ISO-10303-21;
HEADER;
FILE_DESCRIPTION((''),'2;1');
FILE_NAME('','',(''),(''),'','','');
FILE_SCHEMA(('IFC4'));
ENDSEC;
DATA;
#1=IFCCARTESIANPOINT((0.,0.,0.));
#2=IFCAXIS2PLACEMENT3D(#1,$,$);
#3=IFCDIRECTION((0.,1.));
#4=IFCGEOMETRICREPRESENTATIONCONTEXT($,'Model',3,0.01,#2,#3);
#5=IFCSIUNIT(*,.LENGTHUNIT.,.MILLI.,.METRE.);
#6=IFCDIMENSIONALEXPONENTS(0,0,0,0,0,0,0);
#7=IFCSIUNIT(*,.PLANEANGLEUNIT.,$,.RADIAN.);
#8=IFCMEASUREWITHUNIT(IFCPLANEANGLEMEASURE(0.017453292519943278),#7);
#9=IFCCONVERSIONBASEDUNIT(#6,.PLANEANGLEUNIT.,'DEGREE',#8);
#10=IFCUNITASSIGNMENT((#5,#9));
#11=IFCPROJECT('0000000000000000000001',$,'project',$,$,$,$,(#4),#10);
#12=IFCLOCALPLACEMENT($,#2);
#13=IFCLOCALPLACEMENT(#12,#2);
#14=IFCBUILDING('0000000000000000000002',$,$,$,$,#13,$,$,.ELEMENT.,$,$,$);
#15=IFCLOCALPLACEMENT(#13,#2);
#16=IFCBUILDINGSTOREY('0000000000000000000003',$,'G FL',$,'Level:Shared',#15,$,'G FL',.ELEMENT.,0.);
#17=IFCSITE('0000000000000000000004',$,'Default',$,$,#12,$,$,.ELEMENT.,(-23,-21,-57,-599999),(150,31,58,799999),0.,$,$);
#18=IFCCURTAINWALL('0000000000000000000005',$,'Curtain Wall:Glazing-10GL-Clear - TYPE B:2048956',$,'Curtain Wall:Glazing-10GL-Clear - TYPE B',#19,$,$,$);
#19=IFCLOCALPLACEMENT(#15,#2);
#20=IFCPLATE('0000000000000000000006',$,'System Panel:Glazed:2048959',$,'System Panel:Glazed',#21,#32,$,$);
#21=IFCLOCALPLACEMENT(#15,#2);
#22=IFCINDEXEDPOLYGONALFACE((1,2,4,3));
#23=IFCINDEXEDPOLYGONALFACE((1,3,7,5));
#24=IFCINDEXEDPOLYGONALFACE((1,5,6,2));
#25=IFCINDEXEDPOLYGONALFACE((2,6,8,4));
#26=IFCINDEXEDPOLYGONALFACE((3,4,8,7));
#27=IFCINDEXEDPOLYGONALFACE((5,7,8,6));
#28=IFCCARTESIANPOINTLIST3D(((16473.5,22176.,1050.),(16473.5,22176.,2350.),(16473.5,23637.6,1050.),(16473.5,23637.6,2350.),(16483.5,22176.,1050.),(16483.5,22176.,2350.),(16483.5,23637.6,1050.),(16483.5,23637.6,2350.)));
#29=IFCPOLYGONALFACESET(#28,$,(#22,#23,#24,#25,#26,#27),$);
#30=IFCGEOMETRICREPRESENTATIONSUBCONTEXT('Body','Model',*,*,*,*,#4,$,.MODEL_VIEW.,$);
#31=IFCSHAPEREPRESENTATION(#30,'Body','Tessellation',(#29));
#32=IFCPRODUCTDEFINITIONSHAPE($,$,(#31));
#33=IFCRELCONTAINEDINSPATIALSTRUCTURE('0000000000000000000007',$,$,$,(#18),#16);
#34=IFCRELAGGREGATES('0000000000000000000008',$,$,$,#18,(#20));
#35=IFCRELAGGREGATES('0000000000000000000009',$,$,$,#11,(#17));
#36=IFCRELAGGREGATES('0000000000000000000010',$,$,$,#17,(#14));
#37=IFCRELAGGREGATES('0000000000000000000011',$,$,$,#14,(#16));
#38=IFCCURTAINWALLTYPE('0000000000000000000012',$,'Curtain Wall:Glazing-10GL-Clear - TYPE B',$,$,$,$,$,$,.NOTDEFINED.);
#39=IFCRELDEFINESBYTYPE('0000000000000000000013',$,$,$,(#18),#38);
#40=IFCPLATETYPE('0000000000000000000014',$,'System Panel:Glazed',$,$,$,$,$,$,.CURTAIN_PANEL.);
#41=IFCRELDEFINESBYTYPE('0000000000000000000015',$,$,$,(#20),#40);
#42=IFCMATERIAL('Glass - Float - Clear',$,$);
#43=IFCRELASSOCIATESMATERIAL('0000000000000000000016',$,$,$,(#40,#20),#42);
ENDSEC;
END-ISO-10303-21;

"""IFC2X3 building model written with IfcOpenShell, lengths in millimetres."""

from ifc_helpers import new_model, entity, si_unit, converted_unit, direction, frame, origin, origin_2d_with_axis, place, context, subcontext, project, spatial, rectangle, extrude, source, transform, mapped, material, type_object, type_shapes, element, aggregate, save


model = new_model("IFC2X3")

# Units and contexts
model_context = context("Model", 3, precision=0.01, world=origin(), true_north=direction((0.0, 1.0)))
body_context = subcontext(model_context, "Body", "Model", "MODEL_VIEW")
ifc_project = project(units=[si_unit("LENGTHUNIT", "METRE", prefix="MILLI"), converted_unit("PLANEANGLEUNIT", "DEGREE", entity("IfcPlaneAngleMeasure", 0.017453292519943278), si_unit("PLANEANGLEUNIT", "RADIAN"), dimensions=[0, 0, 0, 0, 0, 0, 0])], contexts=[model_context])

# Site, building, storey
site_placement = place(None, origin())
site = spatial("IfcSite", under=ifc_project, at=site_placement, Name="Default", CompositionType="ELEMENT", RefLatitude=(-23, -21, -57, -599999), RefLongitude=(150, 31, 58, 799999), RefElevation=0.0)
building_placement = place(site_placement, origin())
building = spatial("IfcBuilding", under=site, at=building_placement, CompositionType="ELEMENT")
storey_placement = place(building_placement, origin())
storey = spatial("IfcBuildingStorey", under=building, at=storey_placement, Name="G FL", ObjectType="Level:Shared", LongName="G FL", CompositionType="ELEMENT", Elevation=0.0)

# Shared definitions
curtain_wall_type = type_object("IfcCurtainWallType", Name="Curtain Wall:Glazing-10GL-Clear - TYPE B", PredefinedType="NOTDEFINED")

# Curtain wall
curtain_wall_1_placement = place(storey_placement, origin())
curtain_wall_1 = element("IfcCurtainWall", 1, at=curtain_wall_1_placement, inside=storey, type_object=curtain_wall_type, Name="Curtain Wall:Glazing-10GL-Clear - TYPE B:2048956", ObjectType="Curtain Wall:Glazing-10GL-Clear - TYPE B")

# Plate
ifc_material_1 = material(Name="Glass - Float - Clear")
plate_type = type_object("IfcPlateType", Name="System Panel:Glazed", PredefinedType="CURTAIN_PANEL", material=ifc_material_1)
shared_shape_1 = source(origin(), body_context, "Body", "SweptSolid", [
    extrude(rectangle(XDim=10.0, YDim=1461.7, at=origin_2d_with_axis()), frame((0.0, 0.0, 0.0), z_axis=(0.0, 0.0, 1.0), x_axis=(0.0, 1.0, 0.0)), (0.0, 0.0, 1.0), 1300.0),
])
type_shapes(plate_type, [shared_shape_1])
plate_1_placement = place(curtain_wall_1_placement, frame((16478.5, 22906.8, 1050.0), z_axis=(0.0, 0.0, 1.0), x_axis=(0.0, -1.0, 0.0)))
plate_1 = element("IfcPlate", 2, at=plate_1_placement, type_object=plate_type, material=ifc_material_1, Name="System Panel:Glazed:2048959", ObjectType="System Panel:Glazed", context=body_context, shape_type="MappedRepresentation", body=[
    mapped(shared_shape_1, transform((0.0, 0.0, 0.0), scale=1.0)),
])
aggregate(curtain_wall_1, [plate_1])

save(model, "model.ifc")
